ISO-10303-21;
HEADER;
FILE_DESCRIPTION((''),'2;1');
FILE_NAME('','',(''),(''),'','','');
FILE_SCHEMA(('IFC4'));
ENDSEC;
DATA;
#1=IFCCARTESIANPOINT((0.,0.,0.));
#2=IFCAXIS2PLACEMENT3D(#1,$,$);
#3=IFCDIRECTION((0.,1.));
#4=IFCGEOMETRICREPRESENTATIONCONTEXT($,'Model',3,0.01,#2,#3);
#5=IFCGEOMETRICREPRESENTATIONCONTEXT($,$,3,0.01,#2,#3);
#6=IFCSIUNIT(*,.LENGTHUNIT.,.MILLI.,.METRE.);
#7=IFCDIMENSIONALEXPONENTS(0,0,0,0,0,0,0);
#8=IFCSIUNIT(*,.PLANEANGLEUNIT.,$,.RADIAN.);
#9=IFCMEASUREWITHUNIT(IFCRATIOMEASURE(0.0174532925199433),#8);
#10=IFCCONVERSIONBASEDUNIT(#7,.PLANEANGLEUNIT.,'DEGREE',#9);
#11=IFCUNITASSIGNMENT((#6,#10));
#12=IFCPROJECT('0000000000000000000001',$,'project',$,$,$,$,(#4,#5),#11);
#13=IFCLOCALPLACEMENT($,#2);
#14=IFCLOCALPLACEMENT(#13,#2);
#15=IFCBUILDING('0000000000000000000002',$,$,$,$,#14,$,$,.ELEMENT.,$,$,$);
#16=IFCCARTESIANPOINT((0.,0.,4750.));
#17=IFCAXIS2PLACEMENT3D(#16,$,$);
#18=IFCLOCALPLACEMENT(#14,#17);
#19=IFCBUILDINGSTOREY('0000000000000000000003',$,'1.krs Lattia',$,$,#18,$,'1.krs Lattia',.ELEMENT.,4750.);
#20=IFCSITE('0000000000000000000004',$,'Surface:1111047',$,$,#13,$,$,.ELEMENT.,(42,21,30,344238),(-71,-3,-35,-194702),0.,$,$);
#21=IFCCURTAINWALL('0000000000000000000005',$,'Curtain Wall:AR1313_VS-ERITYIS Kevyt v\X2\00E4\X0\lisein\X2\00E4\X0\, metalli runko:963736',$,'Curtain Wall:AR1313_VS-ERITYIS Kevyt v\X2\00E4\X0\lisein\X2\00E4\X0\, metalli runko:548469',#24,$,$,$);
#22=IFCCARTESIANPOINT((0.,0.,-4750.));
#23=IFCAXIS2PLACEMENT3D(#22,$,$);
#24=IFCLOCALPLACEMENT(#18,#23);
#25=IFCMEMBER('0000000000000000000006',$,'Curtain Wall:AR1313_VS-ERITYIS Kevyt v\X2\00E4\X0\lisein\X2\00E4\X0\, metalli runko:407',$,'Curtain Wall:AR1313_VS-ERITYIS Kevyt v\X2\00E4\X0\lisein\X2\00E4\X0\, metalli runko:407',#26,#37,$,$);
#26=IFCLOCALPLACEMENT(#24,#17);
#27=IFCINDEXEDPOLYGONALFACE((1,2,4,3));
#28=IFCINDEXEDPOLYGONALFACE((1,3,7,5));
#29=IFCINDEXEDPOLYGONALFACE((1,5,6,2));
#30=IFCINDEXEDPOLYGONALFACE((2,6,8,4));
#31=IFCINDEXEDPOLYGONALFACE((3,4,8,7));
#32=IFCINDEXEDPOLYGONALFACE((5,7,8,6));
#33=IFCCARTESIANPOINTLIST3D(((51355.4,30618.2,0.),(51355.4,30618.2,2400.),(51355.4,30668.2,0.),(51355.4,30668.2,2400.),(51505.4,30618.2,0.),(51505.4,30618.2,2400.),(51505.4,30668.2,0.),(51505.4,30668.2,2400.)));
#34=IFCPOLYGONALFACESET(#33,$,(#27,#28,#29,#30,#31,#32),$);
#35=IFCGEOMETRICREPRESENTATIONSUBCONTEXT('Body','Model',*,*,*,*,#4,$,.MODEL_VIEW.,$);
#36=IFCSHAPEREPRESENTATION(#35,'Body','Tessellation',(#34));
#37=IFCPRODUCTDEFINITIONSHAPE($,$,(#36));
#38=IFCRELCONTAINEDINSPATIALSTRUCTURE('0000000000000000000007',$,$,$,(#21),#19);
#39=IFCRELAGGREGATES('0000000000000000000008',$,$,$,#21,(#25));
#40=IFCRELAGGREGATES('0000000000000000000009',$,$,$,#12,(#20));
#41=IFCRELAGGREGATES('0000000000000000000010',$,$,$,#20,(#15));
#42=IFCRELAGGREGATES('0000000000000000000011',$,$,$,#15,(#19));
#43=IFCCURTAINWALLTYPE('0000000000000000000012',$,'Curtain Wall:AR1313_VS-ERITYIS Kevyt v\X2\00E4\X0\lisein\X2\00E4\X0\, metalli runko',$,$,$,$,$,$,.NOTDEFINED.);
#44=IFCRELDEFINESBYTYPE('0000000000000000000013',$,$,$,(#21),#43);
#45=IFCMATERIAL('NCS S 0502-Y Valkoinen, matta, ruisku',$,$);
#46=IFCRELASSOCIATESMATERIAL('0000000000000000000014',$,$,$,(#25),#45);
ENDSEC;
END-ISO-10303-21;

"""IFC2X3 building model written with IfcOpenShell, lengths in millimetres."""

from ifc_helpers import new_model, entity, si_unit, converted_unit, direction, frame, frame_2d, origin, place, context, subcontext, project, spatial, rectangle, extrude, material, type_object, element, aggregate, save


model = new_model("IFC2X3")

# Units and contexts
model_context = context("Model", 3, precision=0.01, world=origin(), true_north=direction((0.0, 1.0)))
context_of_model = context(None, 3, precision=0.01, world=origin(), true_north=direction((0.0, 1.0)))
body_context = subcontext(model_context, "Body", "Model", "MODEL_VIEW")
ifc_project = project(units=[si_unit("LENGTHUNIT", "METRE", prefix="MILLI"), converted_unit("PLANEANGLEUNIT", "DEGREE", entity("IfcRatioMeasure", 0.0174532925199433), si_unit("PLANEANGLEUNIT", "RADIAN"), dimensions=[0, 0, 0, 0, 0, 0, 0])], contexts=[model_context, context_of_model])

# Site, building, storey
site_placement = place(None, origin())
site = spatial("IfcSite", under=ifc_project, at=site_placement, Name="Surface:1111047", CompositionType="ELEMENT", RefLatitude=(42, 21, 30, 344238), RefLongitude=(-71, -3, -35, -194702), RefElevation=0.0)
building_placement = place(site_placement, origin())
building = spatial("IfcBuilding", under=site, at=building_placement, CompositionType="ELEMENT")
storey_placement = place(building_placement, frame((0.0, 0.0, 4750.0)))
storey = spatial("IfcBuildingStorey", under=building, at=storey_placement, Name="1.krs Lattia", LongName="1.krs Lattia", CompositionType="ELEMENT", Elevation=4750.0)

# Curtain wall, member
curtain_wall_type_1 = type_object("IfcCurtainWallType", Name="Curtain Wall:AR1313_VS-ERITYIS Kevyt väliseinä, metalli runko", PredefinedType="NOTDEFINED")
curtain_wall_1_placement = place(storey_placement, frame((0.0, 0.0, -4750.0)))
curtain_wall_1 = element("IfcCurtainWall", 1, at=curtain_wall_1_placement, inside=storey, type_object=curtain_wall_type_1, Name="Curtain Wall:AR1313_VS-ERITYIS Kevyt väliseinä, metalli runko:963736", ObjectType="Curtain Wall:AR1313_VS-ERITYIS Kevyt väliseinä, metalli runko:548469")
ifc_material_1 = material(Name="NCS S 0502-Y Valkoinen, matta, ruisku")
member_1_placement = place(curtain_wall_1_placement, frame((0.0, 0.0, 4750.0)))
member_1 = element("IfcMember", 2, at=member_1_placement, material=ifc_material_1, Name="Curtain Wall:AR1313_VS-ERITYIS Kevyt väliseinä, metalli runko:407", ObjectType="Curtain Wall:AR1313_VS-ERITYIS Kevyt väliseinä, metalli runko:407", context=body_context, shape_type="SweptSolid", body=[
    extrude(rectangle(XDim=150.0, YDim=50.0, at=frame_2d((0.0, 0.0), x_axis=(1.0, 0.0))), frame((51430.4, 30643.2, 0.0), z_axis=(0.0, 0.0, 1.0), x_axis=(-1.0, 0.0, 0.0)), (0.0, 0.0, 1.0), 2400.0),
])
aggregate(curtain_wall_1, [member_1])

save(model, "model.ifc")
